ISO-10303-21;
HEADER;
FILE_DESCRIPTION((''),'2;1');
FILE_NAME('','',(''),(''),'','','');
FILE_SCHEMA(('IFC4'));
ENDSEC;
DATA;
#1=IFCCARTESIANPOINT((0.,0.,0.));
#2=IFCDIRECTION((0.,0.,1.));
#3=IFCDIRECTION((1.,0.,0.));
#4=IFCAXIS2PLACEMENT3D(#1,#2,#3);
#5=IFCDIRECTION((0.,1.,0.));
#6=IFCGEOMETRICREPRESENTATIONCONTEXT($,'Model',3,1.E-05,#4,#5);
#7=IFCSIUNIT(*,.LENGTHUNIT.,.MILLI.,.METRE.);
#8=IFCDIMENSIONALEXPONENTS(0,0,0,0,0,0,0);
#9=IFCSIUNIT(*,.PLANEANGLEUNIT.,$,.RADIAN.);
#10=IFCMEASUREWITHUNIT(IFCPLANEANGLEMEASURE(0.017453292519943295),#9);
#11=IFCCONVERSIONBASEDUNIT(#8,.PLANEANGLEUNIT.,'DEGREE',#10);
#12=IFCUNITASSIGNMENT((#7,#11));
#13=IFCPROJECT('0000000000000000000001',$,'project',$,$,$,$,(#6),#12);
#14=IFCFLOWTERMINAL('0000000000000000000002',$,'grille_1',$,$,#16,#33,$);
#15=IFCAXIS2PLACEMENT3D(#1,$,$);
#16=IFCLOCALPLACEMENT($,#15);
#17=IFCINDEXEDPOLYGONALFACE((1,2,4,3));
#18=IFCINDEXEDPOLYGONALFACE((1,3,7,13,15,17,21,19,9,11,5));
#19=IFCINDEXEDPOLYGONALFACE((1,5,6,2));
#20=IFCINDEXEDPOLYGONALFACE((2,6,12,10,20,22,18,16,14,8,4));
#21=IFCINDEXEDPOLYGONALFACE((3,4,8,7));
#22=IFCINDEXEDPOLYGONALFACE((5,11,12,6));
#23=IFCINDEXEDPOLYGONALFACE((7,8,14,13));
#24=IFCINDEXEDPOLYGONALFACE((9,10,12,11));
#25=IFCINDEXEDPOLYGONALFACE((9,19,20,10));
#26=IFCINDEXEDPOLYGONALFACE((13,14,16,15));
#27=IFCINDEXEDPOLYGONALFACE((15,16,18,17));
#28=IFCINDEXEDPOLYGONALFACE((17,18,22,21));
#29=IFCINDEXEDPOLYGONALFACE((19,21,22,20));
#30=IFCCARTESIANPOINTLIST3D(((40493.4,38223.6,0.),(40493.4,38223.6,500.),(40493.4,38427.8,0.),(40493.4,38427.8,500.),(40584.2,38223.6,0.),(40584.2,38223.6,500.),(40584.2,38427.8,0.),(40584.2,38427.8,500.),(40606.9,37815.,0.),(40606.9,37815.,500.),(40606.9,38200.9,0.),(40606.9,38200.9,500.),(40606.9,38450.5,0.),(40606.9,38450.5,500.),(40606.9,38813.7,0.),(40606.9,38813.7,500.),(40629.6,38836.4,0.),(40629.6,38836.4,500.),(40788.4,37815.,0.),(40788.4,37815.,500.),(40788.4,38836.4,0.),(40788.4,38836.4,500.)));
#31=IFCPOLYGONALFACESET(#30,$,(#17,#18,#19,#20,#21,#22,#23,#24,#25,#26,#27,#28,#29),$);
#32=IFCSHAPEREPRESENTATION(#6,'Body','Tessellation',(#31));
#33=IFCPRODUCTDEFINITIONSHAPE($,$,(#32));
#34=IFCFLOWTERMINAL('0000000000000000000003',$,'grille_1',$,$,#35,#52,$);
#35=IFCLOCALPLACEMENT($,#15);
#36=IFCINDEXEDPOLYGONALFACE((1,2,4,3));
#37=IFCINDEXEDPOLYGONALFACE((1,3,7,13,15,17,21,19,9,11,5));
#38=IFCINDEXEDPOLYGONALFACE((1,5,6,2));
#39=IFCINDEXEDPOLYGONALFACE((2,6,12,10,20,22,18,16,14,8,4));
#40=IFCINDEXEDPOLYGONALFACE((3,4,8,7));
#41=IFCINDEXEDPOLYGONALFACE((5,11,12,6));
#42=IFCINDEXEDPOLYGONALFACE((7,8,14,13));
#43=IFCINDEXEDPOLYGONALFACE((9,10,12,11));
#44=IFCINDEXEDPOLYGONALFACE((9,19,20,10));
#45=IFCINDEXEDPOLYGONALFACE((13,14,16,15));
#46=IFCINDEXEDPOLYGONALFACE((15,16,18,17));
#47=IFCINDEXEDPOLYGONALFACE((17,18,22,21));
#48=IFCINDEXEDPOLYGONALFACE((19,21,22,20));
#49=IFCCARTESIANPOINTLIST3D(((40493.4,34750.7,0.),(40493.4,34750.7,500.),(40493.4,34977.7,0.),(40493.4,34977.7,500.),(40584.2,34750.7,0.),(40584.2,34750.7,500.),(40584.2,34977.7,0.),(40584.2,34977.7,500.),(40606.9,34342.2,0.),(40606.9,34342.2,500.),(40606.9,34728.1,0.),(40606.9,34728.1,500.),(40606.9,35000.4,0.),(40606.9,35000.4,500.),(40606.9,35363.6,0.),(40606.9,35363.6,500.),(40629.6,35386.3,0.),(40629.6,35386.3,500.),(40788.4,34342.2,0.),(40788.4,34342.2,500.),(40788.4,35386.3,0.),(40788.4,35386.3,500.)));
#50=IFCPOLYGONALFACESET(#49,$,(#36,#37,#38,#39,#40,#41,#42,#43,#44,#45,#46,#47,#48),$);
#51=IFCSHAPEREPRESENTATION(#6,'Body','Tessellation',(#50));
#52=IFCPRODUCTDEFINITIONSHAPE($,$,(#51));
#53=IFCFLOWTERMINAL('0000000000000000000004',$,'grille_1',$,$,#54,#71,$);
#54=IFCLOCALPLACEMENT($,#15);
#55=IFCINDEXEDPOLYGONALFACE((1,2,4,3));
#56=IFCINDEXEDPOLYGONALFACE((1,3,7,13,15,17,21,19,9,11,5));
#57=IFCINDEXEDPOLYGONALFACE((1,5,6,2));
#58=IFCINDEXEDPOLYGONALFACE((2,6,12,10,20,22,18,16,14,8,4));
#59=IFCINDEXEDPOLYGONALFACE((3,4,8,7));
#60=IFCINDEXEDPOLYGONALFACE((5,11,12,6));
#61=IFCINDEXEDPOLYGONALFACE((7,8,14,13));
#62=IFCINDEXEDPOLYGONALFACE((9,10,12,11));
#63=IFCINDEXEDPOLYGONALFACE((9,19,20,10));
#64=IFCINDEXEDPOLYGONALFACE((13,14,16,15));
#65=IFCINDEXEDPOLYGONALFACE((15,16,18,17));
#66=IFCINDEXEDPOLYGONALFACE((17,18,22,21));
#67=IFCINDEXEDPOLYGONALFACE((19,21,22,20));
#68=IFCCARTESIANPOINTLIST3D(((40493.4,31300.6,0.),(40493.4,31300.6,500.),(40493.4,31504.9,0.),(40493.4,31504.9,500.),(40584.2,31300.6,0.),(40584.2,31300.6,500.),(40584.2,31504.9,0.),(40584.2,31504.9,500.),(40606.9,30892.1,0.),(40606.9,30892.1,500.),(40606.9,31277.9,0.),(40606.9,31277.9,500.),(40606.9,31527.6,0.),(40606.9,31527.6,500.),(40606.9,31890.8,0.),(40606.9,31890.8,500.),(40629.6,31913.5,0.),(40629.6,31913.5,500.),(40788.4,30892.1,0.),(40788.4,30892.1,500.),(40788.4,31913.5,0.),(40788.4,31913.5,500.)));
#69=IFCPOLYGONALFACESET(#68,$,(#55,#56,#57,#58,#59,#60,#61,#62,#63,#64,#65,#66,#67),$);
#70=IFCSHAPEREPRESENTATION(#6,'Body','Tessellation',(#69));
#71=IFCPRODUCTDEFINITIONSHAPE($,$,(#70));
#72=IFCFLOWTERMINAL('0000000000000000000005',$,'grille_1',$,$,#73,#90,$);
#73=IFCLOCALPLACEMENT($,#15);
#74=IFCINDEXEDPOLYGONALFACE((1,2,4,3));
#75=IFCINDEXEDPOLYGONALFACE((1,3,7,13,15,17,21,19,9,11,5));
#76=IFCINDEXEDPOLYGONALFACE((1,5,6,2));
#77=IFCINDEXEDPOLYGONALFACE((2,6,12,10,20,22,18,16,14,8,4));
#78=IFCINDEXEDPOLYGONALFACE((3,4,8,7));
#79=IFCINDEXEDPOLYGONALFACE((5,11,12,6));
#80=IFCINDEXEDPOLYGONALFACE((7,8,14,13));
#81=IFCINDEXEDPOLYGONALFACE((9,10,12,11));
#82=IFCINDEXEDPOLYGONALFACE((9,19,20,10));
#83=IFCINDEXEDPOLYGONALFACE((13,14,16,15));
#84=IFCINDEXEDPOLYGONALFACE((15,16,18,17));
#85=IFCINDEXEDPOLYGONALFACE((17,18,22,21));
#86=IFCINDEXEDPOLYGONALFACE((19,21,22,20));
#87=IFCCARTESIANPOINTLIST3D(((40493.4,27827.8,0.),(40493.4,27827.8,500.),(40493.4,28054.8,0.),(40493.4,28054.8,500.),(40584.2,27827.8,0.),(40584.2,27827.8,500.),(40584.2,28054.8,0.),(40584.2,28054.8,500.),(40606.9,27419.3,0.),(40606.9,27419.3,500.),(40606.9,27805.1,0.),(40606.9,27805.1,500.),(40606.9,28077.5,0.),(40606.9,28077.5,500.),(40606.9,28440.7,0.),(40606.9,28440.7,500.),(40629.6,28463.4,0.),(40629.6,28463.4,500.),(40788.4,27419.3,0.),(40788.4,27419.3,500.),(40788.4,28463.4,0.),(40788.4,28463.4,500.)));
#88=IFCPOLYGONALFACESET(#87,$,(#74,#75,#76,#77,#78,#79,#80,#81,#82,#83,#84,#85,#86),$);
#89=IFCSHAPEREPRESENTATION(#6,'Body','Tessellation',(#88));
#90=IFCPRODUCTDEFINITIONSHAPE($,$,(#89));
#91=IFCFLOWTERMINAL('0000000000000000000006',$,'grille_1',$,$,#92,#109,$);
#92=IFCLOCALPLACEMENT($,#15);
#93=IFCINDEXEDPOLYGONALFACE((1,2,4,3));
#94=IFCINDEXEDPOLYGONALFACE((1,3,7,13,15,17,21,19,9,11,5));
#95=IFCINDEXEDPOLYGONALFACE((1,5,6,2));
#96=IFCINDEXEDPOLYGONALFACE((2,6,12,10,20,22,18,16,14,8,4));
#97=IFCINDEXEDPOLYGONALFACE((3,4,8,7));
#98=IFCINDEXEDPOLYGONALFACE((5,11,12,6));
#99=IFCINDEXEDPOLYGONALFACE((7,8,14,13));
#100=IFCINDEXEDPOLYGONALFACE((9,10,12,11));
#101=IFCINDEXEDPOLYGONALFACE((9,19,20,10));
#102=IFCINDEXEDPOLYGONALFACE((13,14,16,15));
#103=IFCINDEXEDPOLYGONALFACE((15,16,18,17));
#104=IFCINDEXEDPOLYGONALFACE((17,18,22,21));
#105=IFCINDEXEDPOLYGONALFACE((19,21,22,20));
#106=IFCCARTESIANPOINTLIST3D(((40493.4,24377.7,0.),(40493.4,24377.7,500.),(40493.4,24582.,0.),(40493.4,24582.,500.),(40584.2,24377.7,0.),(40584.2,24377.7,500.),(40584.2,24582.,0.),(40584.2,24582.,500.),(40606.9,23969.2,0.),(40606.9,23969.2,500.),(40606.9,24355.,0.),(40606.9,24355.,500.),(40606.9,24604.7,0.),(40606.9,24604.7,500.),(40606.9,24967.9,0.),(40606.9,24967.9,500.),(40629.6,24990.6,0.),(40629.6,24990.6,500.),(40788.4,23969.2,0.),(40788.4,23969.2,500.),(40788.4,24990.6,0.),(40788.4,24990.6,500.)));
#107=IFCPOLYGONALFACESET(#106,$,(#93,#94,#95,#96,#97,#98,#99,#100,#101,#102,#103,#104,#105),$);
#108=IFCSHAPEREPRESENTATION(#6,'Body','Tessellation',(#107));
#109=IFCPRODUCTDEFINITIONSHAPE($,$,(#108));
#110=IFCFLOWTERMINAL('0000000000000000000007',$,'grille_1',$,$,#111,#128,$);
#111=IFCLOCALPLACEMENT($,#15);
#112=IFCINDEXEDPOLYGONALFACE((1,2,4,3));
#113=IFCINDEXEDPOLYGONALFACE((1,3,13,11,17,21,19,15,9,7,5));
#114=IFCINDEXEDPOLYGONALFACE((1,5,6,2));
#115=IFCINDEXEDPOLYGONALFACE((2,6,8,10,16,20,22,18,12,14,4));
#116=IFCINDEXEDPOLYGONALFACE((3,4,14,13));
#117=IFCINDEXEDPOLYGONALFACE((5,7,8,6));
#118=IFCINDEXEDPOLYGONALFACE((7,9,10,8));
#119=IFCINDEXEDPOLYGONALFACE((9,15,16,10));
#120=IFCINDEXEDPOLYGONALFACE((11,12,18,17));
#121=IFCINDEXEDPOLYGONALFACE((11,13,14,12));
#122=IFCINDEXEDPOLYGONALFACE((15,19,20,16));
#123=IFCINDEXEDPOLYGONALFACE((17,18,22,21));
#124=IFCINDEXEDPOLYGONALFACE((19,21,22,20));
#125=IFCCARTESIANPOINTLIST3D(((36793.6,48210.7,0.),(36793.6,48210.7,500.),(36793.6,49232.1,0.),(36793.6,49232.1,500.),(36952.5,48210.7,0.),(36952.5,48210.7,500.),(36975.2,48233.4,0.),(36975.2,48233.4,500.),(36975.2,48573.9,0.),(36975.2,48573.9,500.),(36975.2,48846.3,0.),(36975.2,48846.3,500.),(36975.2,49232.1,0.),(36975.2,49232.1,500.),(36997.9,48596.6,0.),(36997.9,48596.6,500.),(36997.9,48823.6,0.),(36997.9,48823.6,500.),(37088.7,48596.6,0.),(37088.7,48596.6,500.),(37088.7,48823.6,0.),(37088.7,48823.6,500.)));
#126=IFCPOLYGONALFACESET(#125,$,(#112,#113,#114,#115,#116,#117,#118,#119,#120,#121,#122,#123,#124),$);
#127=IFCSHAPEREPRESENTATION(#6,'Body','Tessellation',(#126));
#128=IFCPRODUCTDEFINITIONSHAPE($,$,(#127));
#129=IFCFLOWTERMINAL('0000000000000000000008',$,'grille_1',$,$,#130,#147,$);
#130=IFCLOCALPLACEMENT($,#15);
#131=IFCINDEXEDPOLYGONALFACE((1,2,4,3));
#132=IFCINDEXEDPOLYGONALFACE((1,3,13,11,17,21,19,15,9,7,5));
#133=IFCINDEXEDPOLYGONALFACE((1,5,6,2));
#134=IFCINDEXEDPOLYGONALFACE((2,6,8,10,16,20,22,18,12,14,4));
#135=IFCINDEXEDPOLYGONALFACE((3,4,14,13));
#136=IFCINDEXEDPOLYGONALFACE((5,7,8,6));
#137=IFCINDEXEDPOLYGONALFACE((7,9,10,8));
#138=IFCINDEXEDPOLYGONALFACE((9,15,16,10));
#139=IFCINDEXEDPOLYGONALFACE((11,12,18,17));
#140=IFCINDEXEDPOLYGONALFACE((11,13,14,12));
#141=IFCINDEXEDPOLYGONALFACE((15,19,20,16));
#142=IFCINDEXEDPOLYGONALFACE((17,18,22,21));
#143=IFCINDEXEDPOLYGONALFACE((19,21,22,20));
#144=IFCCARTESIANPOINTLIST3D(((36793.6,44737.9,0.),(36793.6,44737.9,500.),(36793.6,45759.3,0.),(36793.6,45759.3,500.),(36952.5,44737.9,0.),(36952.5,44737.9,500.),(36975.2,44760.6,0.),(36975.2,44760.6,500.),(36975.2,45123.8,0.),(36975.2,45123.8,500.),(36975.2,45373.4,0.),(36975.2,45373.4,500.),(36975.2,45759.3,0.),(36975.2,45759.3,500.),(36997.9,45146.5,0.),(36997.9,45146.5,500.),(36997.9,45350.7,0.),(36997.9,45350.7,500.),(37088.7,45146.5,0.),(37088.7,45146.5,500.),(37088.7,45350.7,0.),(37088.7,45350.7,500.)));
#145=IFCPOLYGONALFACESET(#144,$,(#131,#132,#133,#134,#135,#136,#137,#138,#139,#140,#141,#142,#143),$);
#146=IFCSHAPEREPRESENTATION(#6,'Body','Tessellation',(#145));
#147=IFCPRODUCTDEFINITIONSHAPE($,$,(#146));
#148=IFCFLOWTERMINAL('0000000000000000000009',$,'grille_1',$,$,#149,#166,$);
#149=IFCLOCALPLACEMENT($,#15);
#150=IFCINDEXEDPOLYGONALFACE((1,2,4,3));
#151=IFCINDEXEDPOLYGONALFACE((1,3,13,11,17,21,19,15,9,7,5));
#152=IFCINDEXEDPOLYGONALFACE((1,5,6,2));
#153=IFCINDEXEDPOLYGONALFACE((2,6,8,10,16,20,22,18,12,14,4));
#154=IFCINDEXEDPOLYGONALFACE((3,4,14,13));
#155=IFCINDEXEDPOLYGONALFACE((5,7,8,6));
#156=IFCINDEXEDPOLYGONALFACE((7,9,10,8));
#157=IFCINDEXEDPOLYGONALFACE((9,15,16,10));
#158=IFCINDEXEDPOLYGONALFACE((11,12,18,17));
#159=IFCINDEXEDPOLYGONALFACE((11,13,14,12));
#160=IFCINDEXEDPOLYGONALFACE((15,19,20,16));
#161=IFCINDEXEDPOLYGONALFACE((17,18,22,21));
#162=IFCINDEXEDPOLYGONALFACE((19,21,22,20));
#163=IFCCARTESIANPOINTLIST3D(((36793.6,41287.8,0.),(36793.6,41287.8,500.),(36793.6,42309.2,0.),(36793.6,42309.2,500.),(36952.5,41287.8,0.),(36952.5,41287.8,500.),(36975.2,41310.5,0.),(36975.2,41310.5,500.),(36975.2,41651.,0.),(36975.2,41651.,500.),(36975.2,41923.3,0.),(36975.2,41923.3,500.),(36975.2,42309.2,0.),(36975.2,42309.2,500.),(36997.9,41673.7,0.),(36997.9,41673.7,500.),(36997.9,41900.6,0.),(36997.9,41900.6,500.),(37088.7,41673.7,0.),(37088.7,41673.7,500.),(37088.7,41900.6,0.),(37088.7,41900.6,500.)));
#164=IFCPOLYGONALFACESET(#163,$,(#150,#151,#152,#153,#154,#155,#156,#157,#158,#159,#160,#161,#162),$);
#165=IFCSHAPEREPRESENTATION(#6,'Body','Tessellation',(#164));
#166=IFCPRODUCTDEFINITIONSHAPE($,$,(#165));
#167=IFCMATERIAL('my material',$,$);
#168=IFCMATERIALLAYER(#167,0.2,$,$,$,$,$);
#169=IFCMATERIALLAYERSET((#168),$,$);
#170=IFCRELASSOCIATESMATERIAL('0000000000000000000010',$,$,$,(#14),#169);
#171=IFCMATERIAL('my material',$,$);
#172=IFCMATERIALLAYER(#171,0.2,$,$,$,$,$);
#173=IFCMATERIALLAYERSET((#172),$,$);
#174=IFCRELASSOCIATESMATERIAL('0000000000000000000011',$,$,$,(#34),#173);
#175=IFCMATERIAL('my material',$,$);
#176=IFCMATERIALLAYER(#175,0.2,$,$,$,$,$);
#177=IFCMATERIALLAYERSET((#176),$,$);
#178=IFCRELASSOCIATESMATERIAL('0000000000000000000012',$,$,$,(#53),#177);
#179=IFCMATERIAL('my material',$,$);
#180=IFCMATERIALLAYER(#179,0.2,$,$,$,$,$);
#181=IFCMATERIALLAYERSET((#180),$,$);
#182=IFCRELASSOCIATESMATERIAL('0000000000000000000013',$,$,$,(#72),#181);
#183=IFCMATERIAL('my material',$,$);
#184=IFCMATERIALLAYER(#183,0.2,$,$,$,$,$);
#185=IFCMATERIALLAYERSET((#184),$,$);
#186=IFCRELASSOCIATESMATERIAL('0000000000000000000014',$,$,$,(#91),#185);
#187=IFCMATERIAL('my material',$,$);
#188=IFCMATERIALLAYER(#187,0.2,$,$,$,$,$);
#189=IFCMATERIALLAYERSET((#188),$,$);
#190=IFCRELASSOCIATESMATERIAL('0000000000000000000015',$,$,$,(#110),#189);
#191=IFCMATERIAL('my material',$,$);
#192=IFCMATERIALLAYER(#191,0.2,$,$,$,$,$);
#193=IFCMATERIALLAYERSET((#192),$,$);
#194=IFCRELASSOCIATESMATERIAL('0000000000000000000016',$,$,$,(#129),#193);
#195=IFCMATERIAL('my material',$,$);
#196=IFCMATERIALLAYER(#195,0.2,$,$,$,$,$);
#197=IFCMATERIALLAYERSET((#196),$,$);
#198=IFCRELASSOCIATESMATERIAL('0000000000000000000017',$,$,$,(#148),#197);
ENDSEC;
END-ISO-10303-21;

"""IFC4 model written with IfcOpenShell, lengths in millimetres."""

from ifc_helpers import new_model, entity, si_unit, converted_unit, direction, origin_with_axes, place, context, project, polyline, outline, extrude, material, layer, layer_set, layer_usage, element, save


model = new_model("IFC4")

# Units and contexts
model_context = context("Model", 3, precision=1e-05, world=origin_with_axes(), true_north=direction((0.0, 1.0, 0.0)))
ifc_project = project(units=[si_unit("LENGTHUNIT", "METRE", prefix="MILLI"), converted_unit("PLANEANGLEUNIT", "DEGREE", entity("IfcPlaneAngleMeasure", 0.017453292519943295), si_unit("PLANEANGLEUNIT", "RADIAN"), dimensions=[0, 0, 0, 0, 0, 0, 0])], contexts=[model_context])

# Flow terminals
ifc_material_1 = material(Name="my material")
ifc_layer_1 = layer(ifc_material_1, 0.2)
ifc_layer_set_1 = layer_set([ifc_layer_1])
ifc_layer_usage_1 = layer_usage(ifc_layer_set_1, "AXIS2", "POSITIVE", -0.1)
flow_terminal_1_placement = place(None, origin_with_axes())
element("IfcFlowTerminal", 1, at=flow_terminal_1_placement, material=ifc_layer_usage_1, Name="grille_1", context=model_context, shape_type="SweptSolid", body=[
    extrude(outline(polyline([(40493.4, 38223.6), (40584.2, 38223.6), (40606.9, 38200.9), (40606.9, 37815.0), (40788.4, 37815.0), (40788.4, 38836.4), (40629.6, 38836.4), (40606.9, 38813.7), (40606.9, 38450.5), (40584.2, 38427.8), (40493.4, 38427.8), (40493.4, 38223.6)])), origin_with_axes(), (0.0, 0.0, 1.0), 500.0),
])
ifc_material_2 = material(Name="my material")
ifc_layer_2 = layer(ifc_material_2, 0.2)
ifc_layer_set_2 = layer_set([ifc_layer_2])
ifc_layer_usage_2 = layer_usage(ifc_layer_set_2, "AXIS2", "POSITIVE", -0.1)
flow_terminal_2_placement = place(None, origin_with_axes())
element("IfcFlowTerminal", 2, at=flow_terminal_2_placement, material=ifc_layer_usage_2, Name="grille_1", context=model_context, shape_type="SweptSolid", body=[
    extrude(outline(polyline([(40493.4, 34750.7), (40584.2, 34750.7), (40606.9, 34728.1), (40606.9, 34342.2), (40788.4, 34342.2), (40788.4, 35386.3), (40629.6, 35386.3), (40606.9, 35363.6), (40606.9, 35000.4), (40584.2, 34977.7), (40493.4, 34977.7), (40493.4, 34750.7)])), origin_with_axes(), (0.0, 0.0, 1.0), 500.0),
])
ifc_material_3 = material(Name="my material")
ifc_layer_3 = layer(ifc_material_3, 0.2)
ifc_layer_set_3 = layer_set([ifc_layer_3])
ifc_layer_usage_3 = layer_usage(ifc_layer_set_3, "AXIS2", "POSITIVE", -0.1)
flow_terminal_3_placement = place(None, origin_with_axes())
element("IfcFlowTerminal", 3, at=flow_terminal_3_placement, material=ifc_layer_usage_3, Name="grille_1", context=model_context, shape_type="SweptSolid", body=[
    extrude(outline(polyline([(40493.4, 31300.6), (40584.2, 31300.6), (40606.9, 31277.9), (40606.9, 30892.1), (40788.4, 30892.1), (40788.4, 31913.5), (40629.6, 31913.5), (40606.9, 31890.8), (40606.9, 31527.6), (40584.2, 31504.9), (40493.4, 31504.9), (40493.4, 31300.6)])), origin_with_axes(), (0.0, 0.0, 1.0), 500.0),
])
ifc_material_4 = material(Name="my material")
ifc_layer_4 = layer(ifc_material_4, 0.2)
ifc_layer_set_4 = layer_set([ifc_layer_4])
ifc_layer_usage_4 = layer_usage(ifc_layer_set_4, "AXIS2", "POSITIVE", -0.1)
flow_terminal_4_placement = place(None, origin_with_axes())
element("IfcFlowTerminal", 4, at=flow_terminal_4_placement, material=ifc_layer_usage_4, Name="grille_1", context=model_context, shape_type="SweptSolid", body=[
    extrude(outline(polyline([(40493.4, 27827.8), (40584.2, 27827.8), (40606.9, 27805.1), (40606.9, 27419.3), (40788.4, 27419.3), (40788.4, 28463.4), (40629.6, 28463.4), (40606.9, 28440.7), (40606.9, 28077.5), (40584.2, 28054.8), (40493.4, 28054.8), (40493.4, 27827.8)])), origin_with_axes(), (0.0, 0.0, 1.0), 500.0),
])
ifc_material_5 = material(Name="my material")
ifc_layer_5 = layer(ifc_material_5, 0.2)
ifc_layer_set_5 = layer_set([ifc_layer_5])
ifc_layer_usage_5 = layer_usage(ifc_layer_set_5, "AXIS2", "POSITIVE", -0.1)
flow_terminal_5_placement = place(None, origin_with_axes())
element("IfcFlowTerminal", 5, at=flow_terminal_5_placement, material=ifc_layer_usage_5, Name="grille_1", context=model_context, shape_type="SweptSolid", body=[
    extrude(outline(polyline([(40493.4, 24377.7), (40584.2, 24377.7), (40606.9, 24355.0), (40606.9, 23969.2), (40788.4, 23969.2), (40788.4, 24990.6), (40629.6, 24990.6), (40606.9, 24967.9), (40606.9, 24604.7), (40584.2, 24582.0), (40493.4, 24582.0), (40493.4, 24377.7)])), origin_with_axes(), (0.0, 0.0, 1.0), 500.0),
])
ifc_material_6 = material(Name="my material")
ifc_layer_6 = layer(ifc_material_6, 0.2)
ifc_layer_set_6 = layer_set([ifc_layer_6])
ifc_layer_usage_6 = layer_usage(ifc_layer_set_6, "AXIS2", "POSITIVE", -0.1)
flow_terminal_6_placement = place(None, origin_with_axes())
element("IfcFlowTerminal", 6, at=flow_terminal_6_placement, material=ifc_layer_usage_6, Name="grille_1", context=model_context, shape_type="SweptSolid", body=[
    extrude(outline(polyline([(36793.6, 48210.7), (36952.5, 48210.7), (36975.2, 48233.4), (36975.2, 48573.9), (36997.9, 48596.6), (37088.7, 48596.6), (37088.7, 48823.6), (36997.9, 48823.6), (36975.2, 48846.3), (36975.2, 49232.1), (36793.6, 49232.1), (36793.6, 48210.7)])), origin_with_axes(), (0.0, 0.0, 1.0), 500.0),
])
ifc_material_7 = material(Name="my material")
ifc_layer_7 = layer(ifc_material_7, 0.2)
ifc_layer_set_7 = layer_set([ifc_layer_7])
ifc_layer_usage_7 = layer_usage(ifc_layer_set_7, "AXIS2", "POSITIVE", -0.1)
flow_terminal_7_placement = place(None, origin_with_axes())
element("IfcFlowTerminal", 7, at=flow_terminal_7_placement, material=ifc_layer_usage_7, Name="grille_1", context=model_context, shape_type="SweptSolid", body=[
    extrude(outline(polyline([(36793.6, 44737.9), (36952.5, 44737.9), (36975.2, 44760.6), (36975.2, 45123.8), (36997.9, 45146.5), (37088.7, 45146.5), (37088.7, 45350.7), (36997.9, 45350.7), (36975.2, 45373.4), (36975.2, 45759.3), (36793.6, 45759.3), (36793.6, 44737.9)])), origin_with_axes(), (0.0, 0.0, 1.0), 500.0),
])
ifc_material_8 = material(Name="my material")
ifc_layer_8 = layer(ifc_material_8, 0.2)
ifc_layer_set_8 = layer_set([ifc_layer_8])
ifc_layer_usage_8 = layer_usage(ifc_layer_set_8, "AXIS2", "POSITIVE", -0.1)
flow_terminal_8_placement = place(None, origin_with_axes())
element("IfcFlowTerminal", 8, at=flow_terminal_8_placement, material=ifc_layer_usage_8, Name="grille_1", context=model_context, shape_type="SweptSolid", body=[
    extrude(outline(polyline([(36793.6, 41287.8), (36952.5, 41287.8), (36975.2, 41310.5), (36975.2, 41651.0), (36997.9, 41673.7), (37088.7, 41673.7), (37088.7, 41900.6), (36997.9, 41900.6), (36975.2, 41923.3), (36975.2, 42309.2), (36793.6, 42309.2), (36793.6, 41287.8)])), origin_with_axes(), (0.0, 0.0, 1.0), 500.0),
])

save(model, "model.ifc")
